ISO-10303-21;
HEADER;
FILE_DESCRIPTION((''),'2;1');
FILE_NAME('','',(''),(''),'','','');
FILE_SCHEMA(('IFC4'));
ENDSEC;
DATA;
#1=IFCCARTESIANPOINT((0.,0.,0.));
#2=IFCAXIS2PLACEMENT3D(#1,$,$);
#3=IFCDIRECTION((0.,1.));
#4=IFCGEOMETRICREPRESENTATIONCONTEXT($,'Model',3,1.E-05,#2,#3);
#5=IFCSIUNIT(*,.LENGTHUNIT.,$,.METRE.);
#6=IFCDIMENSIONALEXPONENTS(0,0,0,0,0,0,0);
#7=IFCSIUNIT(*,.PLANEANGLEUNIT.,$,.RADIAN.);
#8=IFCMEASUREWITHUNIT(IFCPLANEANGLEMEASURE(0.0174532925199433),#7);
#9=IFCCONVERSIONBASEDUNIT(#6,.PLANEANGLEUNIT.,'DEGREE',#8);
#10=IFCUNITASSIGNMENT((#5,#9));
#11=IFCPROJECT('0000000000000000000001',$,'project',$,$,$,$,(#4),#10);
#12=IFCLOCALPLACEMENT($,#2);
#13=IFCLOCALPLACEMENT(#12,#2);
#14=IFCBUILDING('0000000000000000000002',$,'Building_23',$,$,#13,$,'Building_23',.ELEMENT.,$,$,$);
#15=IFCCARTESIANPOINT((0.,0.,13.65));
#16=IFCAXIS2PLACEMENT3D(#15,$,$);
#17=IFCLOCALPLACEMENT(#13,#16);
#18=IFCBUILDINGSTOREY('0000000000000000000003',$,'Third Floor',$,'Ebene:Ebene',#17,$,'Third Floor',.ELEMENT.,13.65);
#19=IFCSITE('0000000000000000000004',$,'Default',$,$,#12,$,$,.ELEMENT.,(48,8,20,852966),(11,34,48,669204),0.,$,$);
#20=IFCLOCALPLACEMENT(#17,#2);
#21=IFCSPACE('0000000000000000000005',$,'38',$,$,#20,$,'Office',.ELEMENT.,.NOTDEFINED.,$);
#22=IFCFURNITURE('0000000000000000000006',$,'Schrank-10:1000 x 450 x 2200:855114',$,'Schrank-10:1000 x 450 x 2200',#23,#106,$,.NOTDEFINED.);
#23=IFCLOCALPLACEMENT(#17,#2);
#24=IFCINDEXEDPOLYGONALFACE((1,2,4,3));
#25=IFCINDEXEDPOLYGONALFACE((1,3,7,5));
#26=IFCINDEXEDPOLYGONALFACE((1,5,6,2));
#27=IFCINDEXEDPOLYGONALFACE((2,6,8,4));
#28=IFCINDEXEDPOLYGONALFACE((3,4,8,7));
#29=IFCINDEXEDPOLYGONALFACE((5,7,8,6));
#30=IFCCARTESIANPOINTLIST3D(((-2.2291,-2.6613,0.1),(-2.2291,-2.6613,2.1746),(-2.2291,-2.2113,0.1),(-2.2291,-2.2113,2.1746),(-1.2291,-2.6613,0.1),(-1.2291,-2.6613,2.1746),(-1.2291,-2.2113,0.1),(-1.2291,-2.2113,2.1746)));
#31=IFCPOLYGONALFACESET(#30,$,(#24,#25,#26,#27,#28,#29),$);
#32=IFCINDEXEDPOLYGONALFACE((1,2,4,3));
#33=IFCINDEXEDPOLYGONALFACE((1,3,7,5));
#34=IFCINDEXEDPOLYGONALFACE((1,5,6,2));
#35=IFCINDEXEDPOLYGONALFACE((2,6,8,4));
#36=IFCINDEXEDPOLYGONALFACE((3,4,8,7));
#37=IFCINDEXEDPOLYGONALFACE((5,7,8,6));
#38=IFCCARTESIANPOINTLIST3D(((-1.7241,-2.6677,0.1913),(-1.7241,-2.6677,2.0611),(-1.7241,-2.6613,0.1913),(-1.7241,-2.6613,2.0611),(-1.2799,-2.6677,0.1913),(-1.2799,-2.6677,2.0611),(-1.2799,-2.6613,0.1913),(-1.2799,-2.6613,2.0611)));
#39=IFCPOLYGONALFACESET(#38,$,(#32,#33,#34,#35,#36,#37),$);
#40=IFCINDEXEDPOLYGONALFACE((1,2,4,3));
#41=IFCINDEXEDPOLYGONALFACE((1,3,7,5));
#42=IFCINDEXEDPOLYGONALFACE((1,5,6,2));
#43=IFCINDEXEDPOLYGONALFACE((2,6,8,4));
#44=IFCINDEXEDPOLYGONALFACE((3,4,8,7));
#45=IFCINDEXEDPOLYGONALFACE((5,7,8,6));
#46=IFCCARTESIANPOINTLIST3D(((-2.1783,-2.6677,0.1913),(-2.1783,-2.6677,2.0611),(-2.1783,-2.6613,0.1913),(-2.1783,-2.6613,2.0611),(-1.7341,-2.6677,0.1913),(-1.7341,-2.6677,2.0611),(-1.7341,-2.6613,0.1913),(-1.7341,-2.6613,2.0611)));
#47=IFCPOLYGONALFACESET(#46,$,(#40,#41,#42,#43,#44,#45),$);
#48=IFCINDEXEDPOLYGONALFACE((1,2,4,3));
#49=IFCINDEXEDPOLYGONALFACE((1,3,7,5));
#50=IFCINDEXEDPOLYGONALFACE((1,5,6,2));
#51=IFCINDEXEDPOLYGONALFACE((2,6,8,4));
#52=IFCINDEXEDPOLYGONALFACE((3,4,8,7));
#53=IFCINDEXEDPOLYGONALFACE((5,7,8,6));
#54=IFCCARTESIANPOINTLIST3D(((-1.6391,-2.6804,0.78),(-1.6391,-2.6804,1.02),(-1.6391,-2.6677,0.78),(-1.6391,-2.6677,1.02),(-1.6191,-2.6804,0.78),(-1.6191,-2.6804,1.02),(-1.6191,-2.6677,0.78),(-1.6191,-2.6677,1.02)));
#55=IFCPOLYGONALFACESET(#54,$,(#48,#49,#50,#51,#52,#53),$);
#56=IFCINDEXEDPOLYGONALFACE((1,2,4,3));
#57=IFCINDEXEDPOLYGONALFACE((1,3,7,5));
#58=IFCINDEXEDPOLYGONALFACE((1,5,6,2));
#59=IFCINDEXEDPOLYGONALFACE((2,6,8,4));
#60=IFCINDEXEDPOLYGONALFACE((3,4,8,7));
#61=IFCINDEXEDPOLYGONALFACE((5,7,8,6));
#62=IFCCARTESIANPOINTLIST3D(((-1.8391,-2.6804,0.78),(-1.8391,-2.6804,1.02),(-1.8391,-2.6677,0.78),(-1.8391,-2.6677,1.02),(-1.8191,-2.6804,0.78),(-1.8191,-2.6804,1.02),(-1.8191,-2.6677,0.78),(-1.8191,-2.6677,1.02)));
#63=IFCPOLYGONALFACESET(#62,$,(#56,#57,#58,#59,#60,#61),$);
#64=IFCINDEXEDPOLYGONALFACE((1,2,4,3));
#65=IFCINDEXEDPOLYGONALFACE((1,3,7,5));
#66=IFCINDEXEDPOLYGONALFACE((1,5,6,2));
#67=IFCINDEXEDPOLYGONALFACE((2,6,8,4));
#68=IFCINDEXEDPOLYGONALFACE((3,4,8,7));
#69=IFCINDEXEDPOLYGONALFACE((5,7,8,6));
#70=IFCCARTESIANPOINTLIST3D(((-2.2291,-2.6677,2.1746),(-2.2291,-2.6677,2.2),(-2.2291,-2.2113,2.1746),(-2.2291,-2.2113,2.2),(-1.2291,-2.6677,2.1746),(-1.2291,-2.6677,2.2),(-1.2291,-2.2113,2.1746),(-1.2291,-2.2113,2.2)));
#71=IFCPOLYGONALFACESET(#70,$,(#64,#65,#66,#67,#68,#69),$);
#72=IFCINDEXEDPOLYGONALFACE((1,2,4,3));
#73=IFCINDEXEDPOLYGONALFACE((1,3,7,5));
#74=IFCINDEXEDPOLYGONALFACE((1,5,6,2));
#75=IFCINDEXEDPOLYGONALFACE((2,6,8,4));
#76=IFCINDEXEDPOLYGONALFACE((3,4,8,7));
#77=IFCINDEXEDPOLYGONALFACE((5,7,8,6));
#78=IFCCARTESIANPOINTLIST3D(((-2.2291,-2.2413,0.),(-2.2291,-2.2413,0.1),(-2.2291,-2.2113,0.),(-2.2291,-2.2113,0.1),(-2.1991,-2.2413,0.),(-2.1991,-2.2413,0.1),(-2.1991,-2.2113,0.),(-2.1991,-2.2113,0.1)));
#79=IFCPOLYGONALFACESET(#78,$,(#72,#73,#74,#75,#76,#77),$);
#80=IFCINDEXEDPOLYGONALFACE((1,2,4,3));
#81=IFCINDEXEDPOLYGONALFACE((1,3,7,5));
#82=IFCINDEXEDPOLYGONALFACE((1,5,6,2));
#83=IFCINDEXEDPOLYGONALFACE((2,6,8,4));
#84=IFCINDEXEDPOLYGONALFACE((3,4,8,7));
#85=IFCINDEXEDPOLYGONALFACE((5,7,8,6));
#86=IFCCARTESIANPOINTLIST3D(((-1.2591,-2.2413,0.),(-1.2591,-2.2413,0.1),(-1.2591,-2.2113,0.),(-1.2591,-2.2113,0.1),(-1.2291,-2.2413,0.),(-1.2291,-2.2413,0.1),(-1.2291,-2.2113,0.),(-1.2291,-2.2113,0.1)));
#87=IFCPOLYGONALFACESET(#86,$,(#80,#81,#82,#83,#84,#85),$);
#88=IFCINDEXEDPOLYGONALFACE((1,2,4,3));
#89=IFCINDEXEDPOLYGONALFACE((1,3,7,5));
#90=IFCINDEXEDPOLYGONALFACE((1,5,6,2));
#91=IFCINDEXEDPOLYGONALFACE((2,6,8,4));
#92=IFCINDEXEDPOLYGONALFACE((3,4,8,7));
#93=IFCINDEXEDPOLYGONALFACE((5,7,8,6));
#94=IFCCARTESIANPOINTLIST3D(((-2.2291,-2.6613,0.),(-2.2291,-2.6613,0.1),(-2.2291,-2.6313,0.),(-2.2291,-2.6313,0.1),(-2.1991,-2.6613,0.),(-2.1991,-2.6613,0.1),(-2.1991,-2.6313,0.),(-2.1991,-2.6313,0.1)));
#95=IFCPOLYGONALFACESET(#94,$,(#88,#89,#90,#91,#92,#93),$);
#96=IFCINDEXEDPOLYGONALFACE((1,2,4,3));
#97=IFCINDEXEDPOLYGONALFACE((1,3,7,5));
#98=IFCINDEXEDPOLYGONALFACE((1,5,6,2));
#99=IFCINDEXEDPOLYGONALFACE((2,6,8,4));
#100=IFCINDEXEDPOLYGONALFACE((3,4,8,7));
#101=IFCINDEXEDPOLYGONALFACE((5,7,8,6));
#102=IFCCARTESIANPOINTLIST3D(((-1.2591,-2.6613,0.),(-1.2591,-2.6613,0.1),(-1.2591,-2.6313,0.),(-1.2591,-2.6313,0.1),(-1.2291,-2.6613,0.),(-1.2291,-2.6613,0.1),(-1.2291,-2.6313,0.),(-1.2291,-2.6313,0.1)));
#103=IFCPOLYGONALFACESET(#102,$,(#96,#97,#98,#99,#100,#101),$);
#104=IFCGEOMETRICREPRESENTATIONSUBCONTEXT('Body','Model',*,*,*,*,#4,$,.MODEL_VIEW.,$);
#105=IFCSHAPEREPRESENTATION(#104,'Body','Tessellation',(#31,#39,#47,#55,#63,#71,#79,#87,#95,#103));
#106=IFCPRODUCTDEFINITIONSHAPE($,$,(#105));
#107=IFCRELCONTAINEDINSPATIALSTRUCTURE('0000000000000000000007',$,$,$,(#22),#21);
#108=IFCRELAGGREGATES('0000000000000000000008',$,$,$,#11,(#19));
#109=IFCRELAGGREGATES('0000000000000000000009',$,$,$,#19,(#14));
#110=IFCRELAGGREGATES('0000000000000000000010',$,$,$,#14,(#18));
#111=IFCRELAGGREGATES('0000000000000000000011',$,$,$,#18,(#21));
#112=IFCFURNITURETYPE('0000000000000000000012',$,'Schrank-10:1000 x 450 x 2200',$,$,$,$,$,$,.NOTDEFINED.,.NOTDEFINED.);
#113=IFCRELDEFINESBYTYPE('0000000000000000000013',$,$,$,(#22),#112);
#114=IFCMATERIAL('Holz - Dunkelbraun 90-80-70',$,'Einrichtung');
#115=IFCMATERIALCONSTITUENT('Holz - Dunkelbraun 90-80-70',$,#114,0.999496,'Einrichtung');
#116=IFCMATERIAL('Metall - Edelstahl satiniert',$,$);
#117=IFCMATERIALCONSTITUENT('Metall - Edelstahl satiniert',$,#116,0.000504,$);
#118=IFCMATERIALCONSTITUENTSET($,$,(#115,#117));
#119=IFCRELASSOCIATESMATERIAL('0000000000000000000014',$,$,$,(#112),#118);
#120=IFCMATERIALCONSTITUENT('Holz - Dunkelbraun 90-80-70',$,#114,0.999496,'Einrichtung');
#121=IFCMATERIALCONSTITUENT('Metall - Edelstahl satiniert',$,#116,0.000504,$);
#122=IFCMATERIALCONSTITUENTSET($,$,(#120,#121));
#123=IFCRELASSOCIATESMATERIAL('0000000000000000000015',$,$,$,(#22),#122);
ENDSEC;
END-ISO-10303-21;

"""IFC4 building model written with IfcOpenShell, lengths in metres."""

from ifc_helpers import new_model, entity, si_unit, converted_unit, direction, frame, origin, place, context, subcontext, project, spatial, indexed_curve, outline, extrude, source, transform, mapped, material, constituent, constituent_set, type_object, type_shapes, element, save


model = new_model("IFC4")

# Units and contexts
model_context = context("Model", 3, precision=1e-05, world=origin(), true_north=direction((0.0, 1.0)))
body_context = subcontext(model_context, "Body", "Model", "MODEL_VIEW")
ifc_project = project(units=[si_unit("LENGTHUNIT", "METRE"), converted_unit("PLANEANGLEUNIT", "DEGREE", entity("IfcPlaneAngleMeasure", 0.0174532925199433), si_unit("PLANEANGLEUNIT", "RADIAN"), dimensions=[0, 0, 0, 0, 0, 0, 0])], contexts=[model_context])

# Site, building, storey
site_placement = place(None, origin())
site = spatial("IfcSite", under=ifc_project, at=site_placement, Name="Default", CompositionType="ELEMENT", RefLatitude=(48, 8, 20, 852966), RefLongitude=(11, 34, 48, 669204), RefElevation=0.0)
building_placement = place(site_placement, origin())
building = spatial("IfcBuilding", under=site, at=building_placement, Name="Building_23", LongName="Building_23", CompositionType="ELEMENT")
storey_placement = place(building_placement, frame((0.0, 0.0, 13.65)))
storey = spatial("IfcBuildingStorey", under=building, at=storey_placement, Name="Third Floor", ObjectType="Ebene:Ebene", LongName="Third Floor", CompositionType="ELEMENT", Elevation=13.65)

# Shared definitions
space_1_placement = place(storey_placement, origin())
space_1 = spatial("IfcSpace", under=storey, at=space_1_placement, Name="38", LongName="Office", CompositionType="ELEMENT", PredefinedType="NOTDEFINED")

# Furniture
ifc_material_1 = material(Name="Holz - Dunkelbraun 90-80-70", Category="Einrichtung")
ifc_constituent_1 = constituent(ifc_material_1, Name="Holz - Dunkelbraun 90-80-70", Category="Einrichtung", fraction=0.999496)
ifc_material_2 = material(Name="Metall - Edelstahl satiniert")
ifc_constituent_2 = constituent(ifc_material_2, Name="Metall - Edelstahl satiniert", fraction=0.000504)
ifc_constituent_set_1 = constituent_set(constituents=[ifc_constituent_1, ifc_constituent_2])
ifc_constituent_3 = constituent(ifc_material_1, Name="Holz - Dunkelbraun 90-80-70", Category="Einrichtung", fraction=0.999496)
ifc_constituent_4 = constituent(ifc_material_2, Name="Metall - Edelstahl satiniert", fraction=0.000504)
ifc_constituent_set_2 = constituent_set(constituents=[ifc_constituent_3, ifc_constituent_4])
furniture_type_1 = type_object("IfcFurnitureType", Name="Schrank-10:1000 x 450 x 2200", AssemblyPlace="NOTDEFINED", PredefinedType="NOTDEFINED", material=ifc_constituent_set_2)
shared_shape_1 = source(origin(), body_context, "Body", "SweptSolid", [
    extrude(outline(indexed_curve([(-0.225, -0.5), (0.225, -0.5), (0.225, 0.5), (-0.225, 0.5), (-0.225, -0.5)], self_intersect=False)), frame((-0.2692, -0.3632, 0.1), z_axis=(0.0, 0.0, 1.0), x_axis=(0.0, 1.0, 0.0)), (0.0, 0.0, 1.0), 2.0746),
    extrude(outline(indexed_curve([(-0.0032, -0.2221), (0.0032, -0.2221), (0.0032, 0.2221), (-0.0032, 0.2221), (-0.0032, -0.2221)], self_intersect=False)), frame((-0.0421, -0.5913, 0.1913), z_axis=(0.0, 0.0, 1.0), x_axis=(0.0, 1.0, 0.0)), (0.0, 0.0, 1.0), 1.8698),
    extrude(outline(indexed_curve([(-0.0032, -0.2221), (0.0032, -0.2221), (0.0032, 0.2221), (-0.0032, 0.2221), (-0.0032, -0.2221)], self_intersect=False)), frame((-0.4963, -0.5913, 0.1913), z_axis=(0.0, 0.0, 1.0), x_axis=(0.0, 1.0, 0.0)), (0.0, 0.0, 1.0), 1.8698),
    extrude(outline(indexed_curve([(-0.0063, -0.01), (0.0063, -0.01), (0.0063, 0.01), (-0.0063, 0.01), (-0.0063, -0.01)], self_intersect=False)), frame((-0.1692, -0.6009, 0.78), z_axis=(0.0, 0.0, 1.0), x_axis=(0.0, 1.0, 0.0)), (0.0, 0.0, 1.0), 0.24),
    extrude(outline(indexed_curve([(-0.0063, -0.01), (0.0063, -0.01), (0.0063, 0.01), (-0.0063, 0.01), (-0.0063, -0.01)], self_intersect=False)), frame((-0.3692, -0.6009, 0.78), z_axis=(0.0, 0.0, 1.0), x_axis=(0.0, 1.0, 0.0)), (0.0, 0.0, 1.0), 0.24),
    extrude(outline(indexed_curve([(-0.5, -0.2282), (0.5, -0.2282), (0.5, 0.2282), (-0.5, 0.2282), (-0.5, -0.2282)], self_intersect=False)), frame((-0.2692, -0.3663, 2.1746), z_axis=(0.0, 0.0, 1.0), x_axis=(-1.0, 0.0, 0.0)), (0.0, 0.0, 1.0), 0.0254),
    extrude(outline(indexed_curve([(-0.015, -0.015), (0.015, -0.015), (0.015, 0.015), (-0.015, 0.015), (-0.015, -0.015)], self_intersect=False)), frame((-0.7542, -0.1532, 0.0), z_axis=(0.0, 0.0, 1.0), x_axis=(-1.0, 0.0, 0.0)), (0.0, 0.0, 1.0), 0.1),
    extrude(outline(indexed_curve([(-0.015, -0.015), (0.015, -0.015), (0.015, 0.015), (-0.015, 0.015), (-0.015, -0.015)], self_intersect=False)), frame((0.2158, -0.1532, 0.0), z_axis=(0.0, 0.0, 1.0), x_axis=(0.0, -1.0, 0.0)), (0.0, 0.0, 1.0), 0.1),
    extrude(outline(indexed_curve([(-0.015, -0.015), (0.015, -0.015), (0.015, 0.015), (-0.015, 0.015), (-0.015, -0.015)], self_intersect=False)), frame((-0.7542, -0.5732, 0.0), z_axis=(0.0, 0.0, 1.0), x_axis=(0.0, 1.0, 0.0)), (0.0, 0.0, 1.0), 0.1),
    extrude(outline(indexed_curve([(-0.015, -0.015), (0.015, -0.015), (0.015, 0.015), (-0.015, 0.015), (-0.015, -0.015)], self_intersect=False)), frame((0.2158, -0.5732, 0.0)), (0.0, 0.0, 1.0), 0.1),
])
type_shapes(furniture_type_1, [shared_shape_1])
furniture_1_placement = place(space_1_placement, frame((-1.4599, -2.0731, 0.0)))
element("IfcFurniture", 1, at=furniture_1_placement, inside=space_1, type_object=furniture_type_1, material=ifc_constituent_set_1, Name="Schrank-10:1000 x 450 x 2200:855114", ObjectType="Schrank-10:1000 x 450 x 2200", PredefinedType="NOTDEFINED", context=body_context, shape_type="MappedRepresentation", body=[
    mapped(shared_shape_1, transform((0.0, 0.0, 0.0), scale=1.0)),
])

save(model, "model.ifc")
